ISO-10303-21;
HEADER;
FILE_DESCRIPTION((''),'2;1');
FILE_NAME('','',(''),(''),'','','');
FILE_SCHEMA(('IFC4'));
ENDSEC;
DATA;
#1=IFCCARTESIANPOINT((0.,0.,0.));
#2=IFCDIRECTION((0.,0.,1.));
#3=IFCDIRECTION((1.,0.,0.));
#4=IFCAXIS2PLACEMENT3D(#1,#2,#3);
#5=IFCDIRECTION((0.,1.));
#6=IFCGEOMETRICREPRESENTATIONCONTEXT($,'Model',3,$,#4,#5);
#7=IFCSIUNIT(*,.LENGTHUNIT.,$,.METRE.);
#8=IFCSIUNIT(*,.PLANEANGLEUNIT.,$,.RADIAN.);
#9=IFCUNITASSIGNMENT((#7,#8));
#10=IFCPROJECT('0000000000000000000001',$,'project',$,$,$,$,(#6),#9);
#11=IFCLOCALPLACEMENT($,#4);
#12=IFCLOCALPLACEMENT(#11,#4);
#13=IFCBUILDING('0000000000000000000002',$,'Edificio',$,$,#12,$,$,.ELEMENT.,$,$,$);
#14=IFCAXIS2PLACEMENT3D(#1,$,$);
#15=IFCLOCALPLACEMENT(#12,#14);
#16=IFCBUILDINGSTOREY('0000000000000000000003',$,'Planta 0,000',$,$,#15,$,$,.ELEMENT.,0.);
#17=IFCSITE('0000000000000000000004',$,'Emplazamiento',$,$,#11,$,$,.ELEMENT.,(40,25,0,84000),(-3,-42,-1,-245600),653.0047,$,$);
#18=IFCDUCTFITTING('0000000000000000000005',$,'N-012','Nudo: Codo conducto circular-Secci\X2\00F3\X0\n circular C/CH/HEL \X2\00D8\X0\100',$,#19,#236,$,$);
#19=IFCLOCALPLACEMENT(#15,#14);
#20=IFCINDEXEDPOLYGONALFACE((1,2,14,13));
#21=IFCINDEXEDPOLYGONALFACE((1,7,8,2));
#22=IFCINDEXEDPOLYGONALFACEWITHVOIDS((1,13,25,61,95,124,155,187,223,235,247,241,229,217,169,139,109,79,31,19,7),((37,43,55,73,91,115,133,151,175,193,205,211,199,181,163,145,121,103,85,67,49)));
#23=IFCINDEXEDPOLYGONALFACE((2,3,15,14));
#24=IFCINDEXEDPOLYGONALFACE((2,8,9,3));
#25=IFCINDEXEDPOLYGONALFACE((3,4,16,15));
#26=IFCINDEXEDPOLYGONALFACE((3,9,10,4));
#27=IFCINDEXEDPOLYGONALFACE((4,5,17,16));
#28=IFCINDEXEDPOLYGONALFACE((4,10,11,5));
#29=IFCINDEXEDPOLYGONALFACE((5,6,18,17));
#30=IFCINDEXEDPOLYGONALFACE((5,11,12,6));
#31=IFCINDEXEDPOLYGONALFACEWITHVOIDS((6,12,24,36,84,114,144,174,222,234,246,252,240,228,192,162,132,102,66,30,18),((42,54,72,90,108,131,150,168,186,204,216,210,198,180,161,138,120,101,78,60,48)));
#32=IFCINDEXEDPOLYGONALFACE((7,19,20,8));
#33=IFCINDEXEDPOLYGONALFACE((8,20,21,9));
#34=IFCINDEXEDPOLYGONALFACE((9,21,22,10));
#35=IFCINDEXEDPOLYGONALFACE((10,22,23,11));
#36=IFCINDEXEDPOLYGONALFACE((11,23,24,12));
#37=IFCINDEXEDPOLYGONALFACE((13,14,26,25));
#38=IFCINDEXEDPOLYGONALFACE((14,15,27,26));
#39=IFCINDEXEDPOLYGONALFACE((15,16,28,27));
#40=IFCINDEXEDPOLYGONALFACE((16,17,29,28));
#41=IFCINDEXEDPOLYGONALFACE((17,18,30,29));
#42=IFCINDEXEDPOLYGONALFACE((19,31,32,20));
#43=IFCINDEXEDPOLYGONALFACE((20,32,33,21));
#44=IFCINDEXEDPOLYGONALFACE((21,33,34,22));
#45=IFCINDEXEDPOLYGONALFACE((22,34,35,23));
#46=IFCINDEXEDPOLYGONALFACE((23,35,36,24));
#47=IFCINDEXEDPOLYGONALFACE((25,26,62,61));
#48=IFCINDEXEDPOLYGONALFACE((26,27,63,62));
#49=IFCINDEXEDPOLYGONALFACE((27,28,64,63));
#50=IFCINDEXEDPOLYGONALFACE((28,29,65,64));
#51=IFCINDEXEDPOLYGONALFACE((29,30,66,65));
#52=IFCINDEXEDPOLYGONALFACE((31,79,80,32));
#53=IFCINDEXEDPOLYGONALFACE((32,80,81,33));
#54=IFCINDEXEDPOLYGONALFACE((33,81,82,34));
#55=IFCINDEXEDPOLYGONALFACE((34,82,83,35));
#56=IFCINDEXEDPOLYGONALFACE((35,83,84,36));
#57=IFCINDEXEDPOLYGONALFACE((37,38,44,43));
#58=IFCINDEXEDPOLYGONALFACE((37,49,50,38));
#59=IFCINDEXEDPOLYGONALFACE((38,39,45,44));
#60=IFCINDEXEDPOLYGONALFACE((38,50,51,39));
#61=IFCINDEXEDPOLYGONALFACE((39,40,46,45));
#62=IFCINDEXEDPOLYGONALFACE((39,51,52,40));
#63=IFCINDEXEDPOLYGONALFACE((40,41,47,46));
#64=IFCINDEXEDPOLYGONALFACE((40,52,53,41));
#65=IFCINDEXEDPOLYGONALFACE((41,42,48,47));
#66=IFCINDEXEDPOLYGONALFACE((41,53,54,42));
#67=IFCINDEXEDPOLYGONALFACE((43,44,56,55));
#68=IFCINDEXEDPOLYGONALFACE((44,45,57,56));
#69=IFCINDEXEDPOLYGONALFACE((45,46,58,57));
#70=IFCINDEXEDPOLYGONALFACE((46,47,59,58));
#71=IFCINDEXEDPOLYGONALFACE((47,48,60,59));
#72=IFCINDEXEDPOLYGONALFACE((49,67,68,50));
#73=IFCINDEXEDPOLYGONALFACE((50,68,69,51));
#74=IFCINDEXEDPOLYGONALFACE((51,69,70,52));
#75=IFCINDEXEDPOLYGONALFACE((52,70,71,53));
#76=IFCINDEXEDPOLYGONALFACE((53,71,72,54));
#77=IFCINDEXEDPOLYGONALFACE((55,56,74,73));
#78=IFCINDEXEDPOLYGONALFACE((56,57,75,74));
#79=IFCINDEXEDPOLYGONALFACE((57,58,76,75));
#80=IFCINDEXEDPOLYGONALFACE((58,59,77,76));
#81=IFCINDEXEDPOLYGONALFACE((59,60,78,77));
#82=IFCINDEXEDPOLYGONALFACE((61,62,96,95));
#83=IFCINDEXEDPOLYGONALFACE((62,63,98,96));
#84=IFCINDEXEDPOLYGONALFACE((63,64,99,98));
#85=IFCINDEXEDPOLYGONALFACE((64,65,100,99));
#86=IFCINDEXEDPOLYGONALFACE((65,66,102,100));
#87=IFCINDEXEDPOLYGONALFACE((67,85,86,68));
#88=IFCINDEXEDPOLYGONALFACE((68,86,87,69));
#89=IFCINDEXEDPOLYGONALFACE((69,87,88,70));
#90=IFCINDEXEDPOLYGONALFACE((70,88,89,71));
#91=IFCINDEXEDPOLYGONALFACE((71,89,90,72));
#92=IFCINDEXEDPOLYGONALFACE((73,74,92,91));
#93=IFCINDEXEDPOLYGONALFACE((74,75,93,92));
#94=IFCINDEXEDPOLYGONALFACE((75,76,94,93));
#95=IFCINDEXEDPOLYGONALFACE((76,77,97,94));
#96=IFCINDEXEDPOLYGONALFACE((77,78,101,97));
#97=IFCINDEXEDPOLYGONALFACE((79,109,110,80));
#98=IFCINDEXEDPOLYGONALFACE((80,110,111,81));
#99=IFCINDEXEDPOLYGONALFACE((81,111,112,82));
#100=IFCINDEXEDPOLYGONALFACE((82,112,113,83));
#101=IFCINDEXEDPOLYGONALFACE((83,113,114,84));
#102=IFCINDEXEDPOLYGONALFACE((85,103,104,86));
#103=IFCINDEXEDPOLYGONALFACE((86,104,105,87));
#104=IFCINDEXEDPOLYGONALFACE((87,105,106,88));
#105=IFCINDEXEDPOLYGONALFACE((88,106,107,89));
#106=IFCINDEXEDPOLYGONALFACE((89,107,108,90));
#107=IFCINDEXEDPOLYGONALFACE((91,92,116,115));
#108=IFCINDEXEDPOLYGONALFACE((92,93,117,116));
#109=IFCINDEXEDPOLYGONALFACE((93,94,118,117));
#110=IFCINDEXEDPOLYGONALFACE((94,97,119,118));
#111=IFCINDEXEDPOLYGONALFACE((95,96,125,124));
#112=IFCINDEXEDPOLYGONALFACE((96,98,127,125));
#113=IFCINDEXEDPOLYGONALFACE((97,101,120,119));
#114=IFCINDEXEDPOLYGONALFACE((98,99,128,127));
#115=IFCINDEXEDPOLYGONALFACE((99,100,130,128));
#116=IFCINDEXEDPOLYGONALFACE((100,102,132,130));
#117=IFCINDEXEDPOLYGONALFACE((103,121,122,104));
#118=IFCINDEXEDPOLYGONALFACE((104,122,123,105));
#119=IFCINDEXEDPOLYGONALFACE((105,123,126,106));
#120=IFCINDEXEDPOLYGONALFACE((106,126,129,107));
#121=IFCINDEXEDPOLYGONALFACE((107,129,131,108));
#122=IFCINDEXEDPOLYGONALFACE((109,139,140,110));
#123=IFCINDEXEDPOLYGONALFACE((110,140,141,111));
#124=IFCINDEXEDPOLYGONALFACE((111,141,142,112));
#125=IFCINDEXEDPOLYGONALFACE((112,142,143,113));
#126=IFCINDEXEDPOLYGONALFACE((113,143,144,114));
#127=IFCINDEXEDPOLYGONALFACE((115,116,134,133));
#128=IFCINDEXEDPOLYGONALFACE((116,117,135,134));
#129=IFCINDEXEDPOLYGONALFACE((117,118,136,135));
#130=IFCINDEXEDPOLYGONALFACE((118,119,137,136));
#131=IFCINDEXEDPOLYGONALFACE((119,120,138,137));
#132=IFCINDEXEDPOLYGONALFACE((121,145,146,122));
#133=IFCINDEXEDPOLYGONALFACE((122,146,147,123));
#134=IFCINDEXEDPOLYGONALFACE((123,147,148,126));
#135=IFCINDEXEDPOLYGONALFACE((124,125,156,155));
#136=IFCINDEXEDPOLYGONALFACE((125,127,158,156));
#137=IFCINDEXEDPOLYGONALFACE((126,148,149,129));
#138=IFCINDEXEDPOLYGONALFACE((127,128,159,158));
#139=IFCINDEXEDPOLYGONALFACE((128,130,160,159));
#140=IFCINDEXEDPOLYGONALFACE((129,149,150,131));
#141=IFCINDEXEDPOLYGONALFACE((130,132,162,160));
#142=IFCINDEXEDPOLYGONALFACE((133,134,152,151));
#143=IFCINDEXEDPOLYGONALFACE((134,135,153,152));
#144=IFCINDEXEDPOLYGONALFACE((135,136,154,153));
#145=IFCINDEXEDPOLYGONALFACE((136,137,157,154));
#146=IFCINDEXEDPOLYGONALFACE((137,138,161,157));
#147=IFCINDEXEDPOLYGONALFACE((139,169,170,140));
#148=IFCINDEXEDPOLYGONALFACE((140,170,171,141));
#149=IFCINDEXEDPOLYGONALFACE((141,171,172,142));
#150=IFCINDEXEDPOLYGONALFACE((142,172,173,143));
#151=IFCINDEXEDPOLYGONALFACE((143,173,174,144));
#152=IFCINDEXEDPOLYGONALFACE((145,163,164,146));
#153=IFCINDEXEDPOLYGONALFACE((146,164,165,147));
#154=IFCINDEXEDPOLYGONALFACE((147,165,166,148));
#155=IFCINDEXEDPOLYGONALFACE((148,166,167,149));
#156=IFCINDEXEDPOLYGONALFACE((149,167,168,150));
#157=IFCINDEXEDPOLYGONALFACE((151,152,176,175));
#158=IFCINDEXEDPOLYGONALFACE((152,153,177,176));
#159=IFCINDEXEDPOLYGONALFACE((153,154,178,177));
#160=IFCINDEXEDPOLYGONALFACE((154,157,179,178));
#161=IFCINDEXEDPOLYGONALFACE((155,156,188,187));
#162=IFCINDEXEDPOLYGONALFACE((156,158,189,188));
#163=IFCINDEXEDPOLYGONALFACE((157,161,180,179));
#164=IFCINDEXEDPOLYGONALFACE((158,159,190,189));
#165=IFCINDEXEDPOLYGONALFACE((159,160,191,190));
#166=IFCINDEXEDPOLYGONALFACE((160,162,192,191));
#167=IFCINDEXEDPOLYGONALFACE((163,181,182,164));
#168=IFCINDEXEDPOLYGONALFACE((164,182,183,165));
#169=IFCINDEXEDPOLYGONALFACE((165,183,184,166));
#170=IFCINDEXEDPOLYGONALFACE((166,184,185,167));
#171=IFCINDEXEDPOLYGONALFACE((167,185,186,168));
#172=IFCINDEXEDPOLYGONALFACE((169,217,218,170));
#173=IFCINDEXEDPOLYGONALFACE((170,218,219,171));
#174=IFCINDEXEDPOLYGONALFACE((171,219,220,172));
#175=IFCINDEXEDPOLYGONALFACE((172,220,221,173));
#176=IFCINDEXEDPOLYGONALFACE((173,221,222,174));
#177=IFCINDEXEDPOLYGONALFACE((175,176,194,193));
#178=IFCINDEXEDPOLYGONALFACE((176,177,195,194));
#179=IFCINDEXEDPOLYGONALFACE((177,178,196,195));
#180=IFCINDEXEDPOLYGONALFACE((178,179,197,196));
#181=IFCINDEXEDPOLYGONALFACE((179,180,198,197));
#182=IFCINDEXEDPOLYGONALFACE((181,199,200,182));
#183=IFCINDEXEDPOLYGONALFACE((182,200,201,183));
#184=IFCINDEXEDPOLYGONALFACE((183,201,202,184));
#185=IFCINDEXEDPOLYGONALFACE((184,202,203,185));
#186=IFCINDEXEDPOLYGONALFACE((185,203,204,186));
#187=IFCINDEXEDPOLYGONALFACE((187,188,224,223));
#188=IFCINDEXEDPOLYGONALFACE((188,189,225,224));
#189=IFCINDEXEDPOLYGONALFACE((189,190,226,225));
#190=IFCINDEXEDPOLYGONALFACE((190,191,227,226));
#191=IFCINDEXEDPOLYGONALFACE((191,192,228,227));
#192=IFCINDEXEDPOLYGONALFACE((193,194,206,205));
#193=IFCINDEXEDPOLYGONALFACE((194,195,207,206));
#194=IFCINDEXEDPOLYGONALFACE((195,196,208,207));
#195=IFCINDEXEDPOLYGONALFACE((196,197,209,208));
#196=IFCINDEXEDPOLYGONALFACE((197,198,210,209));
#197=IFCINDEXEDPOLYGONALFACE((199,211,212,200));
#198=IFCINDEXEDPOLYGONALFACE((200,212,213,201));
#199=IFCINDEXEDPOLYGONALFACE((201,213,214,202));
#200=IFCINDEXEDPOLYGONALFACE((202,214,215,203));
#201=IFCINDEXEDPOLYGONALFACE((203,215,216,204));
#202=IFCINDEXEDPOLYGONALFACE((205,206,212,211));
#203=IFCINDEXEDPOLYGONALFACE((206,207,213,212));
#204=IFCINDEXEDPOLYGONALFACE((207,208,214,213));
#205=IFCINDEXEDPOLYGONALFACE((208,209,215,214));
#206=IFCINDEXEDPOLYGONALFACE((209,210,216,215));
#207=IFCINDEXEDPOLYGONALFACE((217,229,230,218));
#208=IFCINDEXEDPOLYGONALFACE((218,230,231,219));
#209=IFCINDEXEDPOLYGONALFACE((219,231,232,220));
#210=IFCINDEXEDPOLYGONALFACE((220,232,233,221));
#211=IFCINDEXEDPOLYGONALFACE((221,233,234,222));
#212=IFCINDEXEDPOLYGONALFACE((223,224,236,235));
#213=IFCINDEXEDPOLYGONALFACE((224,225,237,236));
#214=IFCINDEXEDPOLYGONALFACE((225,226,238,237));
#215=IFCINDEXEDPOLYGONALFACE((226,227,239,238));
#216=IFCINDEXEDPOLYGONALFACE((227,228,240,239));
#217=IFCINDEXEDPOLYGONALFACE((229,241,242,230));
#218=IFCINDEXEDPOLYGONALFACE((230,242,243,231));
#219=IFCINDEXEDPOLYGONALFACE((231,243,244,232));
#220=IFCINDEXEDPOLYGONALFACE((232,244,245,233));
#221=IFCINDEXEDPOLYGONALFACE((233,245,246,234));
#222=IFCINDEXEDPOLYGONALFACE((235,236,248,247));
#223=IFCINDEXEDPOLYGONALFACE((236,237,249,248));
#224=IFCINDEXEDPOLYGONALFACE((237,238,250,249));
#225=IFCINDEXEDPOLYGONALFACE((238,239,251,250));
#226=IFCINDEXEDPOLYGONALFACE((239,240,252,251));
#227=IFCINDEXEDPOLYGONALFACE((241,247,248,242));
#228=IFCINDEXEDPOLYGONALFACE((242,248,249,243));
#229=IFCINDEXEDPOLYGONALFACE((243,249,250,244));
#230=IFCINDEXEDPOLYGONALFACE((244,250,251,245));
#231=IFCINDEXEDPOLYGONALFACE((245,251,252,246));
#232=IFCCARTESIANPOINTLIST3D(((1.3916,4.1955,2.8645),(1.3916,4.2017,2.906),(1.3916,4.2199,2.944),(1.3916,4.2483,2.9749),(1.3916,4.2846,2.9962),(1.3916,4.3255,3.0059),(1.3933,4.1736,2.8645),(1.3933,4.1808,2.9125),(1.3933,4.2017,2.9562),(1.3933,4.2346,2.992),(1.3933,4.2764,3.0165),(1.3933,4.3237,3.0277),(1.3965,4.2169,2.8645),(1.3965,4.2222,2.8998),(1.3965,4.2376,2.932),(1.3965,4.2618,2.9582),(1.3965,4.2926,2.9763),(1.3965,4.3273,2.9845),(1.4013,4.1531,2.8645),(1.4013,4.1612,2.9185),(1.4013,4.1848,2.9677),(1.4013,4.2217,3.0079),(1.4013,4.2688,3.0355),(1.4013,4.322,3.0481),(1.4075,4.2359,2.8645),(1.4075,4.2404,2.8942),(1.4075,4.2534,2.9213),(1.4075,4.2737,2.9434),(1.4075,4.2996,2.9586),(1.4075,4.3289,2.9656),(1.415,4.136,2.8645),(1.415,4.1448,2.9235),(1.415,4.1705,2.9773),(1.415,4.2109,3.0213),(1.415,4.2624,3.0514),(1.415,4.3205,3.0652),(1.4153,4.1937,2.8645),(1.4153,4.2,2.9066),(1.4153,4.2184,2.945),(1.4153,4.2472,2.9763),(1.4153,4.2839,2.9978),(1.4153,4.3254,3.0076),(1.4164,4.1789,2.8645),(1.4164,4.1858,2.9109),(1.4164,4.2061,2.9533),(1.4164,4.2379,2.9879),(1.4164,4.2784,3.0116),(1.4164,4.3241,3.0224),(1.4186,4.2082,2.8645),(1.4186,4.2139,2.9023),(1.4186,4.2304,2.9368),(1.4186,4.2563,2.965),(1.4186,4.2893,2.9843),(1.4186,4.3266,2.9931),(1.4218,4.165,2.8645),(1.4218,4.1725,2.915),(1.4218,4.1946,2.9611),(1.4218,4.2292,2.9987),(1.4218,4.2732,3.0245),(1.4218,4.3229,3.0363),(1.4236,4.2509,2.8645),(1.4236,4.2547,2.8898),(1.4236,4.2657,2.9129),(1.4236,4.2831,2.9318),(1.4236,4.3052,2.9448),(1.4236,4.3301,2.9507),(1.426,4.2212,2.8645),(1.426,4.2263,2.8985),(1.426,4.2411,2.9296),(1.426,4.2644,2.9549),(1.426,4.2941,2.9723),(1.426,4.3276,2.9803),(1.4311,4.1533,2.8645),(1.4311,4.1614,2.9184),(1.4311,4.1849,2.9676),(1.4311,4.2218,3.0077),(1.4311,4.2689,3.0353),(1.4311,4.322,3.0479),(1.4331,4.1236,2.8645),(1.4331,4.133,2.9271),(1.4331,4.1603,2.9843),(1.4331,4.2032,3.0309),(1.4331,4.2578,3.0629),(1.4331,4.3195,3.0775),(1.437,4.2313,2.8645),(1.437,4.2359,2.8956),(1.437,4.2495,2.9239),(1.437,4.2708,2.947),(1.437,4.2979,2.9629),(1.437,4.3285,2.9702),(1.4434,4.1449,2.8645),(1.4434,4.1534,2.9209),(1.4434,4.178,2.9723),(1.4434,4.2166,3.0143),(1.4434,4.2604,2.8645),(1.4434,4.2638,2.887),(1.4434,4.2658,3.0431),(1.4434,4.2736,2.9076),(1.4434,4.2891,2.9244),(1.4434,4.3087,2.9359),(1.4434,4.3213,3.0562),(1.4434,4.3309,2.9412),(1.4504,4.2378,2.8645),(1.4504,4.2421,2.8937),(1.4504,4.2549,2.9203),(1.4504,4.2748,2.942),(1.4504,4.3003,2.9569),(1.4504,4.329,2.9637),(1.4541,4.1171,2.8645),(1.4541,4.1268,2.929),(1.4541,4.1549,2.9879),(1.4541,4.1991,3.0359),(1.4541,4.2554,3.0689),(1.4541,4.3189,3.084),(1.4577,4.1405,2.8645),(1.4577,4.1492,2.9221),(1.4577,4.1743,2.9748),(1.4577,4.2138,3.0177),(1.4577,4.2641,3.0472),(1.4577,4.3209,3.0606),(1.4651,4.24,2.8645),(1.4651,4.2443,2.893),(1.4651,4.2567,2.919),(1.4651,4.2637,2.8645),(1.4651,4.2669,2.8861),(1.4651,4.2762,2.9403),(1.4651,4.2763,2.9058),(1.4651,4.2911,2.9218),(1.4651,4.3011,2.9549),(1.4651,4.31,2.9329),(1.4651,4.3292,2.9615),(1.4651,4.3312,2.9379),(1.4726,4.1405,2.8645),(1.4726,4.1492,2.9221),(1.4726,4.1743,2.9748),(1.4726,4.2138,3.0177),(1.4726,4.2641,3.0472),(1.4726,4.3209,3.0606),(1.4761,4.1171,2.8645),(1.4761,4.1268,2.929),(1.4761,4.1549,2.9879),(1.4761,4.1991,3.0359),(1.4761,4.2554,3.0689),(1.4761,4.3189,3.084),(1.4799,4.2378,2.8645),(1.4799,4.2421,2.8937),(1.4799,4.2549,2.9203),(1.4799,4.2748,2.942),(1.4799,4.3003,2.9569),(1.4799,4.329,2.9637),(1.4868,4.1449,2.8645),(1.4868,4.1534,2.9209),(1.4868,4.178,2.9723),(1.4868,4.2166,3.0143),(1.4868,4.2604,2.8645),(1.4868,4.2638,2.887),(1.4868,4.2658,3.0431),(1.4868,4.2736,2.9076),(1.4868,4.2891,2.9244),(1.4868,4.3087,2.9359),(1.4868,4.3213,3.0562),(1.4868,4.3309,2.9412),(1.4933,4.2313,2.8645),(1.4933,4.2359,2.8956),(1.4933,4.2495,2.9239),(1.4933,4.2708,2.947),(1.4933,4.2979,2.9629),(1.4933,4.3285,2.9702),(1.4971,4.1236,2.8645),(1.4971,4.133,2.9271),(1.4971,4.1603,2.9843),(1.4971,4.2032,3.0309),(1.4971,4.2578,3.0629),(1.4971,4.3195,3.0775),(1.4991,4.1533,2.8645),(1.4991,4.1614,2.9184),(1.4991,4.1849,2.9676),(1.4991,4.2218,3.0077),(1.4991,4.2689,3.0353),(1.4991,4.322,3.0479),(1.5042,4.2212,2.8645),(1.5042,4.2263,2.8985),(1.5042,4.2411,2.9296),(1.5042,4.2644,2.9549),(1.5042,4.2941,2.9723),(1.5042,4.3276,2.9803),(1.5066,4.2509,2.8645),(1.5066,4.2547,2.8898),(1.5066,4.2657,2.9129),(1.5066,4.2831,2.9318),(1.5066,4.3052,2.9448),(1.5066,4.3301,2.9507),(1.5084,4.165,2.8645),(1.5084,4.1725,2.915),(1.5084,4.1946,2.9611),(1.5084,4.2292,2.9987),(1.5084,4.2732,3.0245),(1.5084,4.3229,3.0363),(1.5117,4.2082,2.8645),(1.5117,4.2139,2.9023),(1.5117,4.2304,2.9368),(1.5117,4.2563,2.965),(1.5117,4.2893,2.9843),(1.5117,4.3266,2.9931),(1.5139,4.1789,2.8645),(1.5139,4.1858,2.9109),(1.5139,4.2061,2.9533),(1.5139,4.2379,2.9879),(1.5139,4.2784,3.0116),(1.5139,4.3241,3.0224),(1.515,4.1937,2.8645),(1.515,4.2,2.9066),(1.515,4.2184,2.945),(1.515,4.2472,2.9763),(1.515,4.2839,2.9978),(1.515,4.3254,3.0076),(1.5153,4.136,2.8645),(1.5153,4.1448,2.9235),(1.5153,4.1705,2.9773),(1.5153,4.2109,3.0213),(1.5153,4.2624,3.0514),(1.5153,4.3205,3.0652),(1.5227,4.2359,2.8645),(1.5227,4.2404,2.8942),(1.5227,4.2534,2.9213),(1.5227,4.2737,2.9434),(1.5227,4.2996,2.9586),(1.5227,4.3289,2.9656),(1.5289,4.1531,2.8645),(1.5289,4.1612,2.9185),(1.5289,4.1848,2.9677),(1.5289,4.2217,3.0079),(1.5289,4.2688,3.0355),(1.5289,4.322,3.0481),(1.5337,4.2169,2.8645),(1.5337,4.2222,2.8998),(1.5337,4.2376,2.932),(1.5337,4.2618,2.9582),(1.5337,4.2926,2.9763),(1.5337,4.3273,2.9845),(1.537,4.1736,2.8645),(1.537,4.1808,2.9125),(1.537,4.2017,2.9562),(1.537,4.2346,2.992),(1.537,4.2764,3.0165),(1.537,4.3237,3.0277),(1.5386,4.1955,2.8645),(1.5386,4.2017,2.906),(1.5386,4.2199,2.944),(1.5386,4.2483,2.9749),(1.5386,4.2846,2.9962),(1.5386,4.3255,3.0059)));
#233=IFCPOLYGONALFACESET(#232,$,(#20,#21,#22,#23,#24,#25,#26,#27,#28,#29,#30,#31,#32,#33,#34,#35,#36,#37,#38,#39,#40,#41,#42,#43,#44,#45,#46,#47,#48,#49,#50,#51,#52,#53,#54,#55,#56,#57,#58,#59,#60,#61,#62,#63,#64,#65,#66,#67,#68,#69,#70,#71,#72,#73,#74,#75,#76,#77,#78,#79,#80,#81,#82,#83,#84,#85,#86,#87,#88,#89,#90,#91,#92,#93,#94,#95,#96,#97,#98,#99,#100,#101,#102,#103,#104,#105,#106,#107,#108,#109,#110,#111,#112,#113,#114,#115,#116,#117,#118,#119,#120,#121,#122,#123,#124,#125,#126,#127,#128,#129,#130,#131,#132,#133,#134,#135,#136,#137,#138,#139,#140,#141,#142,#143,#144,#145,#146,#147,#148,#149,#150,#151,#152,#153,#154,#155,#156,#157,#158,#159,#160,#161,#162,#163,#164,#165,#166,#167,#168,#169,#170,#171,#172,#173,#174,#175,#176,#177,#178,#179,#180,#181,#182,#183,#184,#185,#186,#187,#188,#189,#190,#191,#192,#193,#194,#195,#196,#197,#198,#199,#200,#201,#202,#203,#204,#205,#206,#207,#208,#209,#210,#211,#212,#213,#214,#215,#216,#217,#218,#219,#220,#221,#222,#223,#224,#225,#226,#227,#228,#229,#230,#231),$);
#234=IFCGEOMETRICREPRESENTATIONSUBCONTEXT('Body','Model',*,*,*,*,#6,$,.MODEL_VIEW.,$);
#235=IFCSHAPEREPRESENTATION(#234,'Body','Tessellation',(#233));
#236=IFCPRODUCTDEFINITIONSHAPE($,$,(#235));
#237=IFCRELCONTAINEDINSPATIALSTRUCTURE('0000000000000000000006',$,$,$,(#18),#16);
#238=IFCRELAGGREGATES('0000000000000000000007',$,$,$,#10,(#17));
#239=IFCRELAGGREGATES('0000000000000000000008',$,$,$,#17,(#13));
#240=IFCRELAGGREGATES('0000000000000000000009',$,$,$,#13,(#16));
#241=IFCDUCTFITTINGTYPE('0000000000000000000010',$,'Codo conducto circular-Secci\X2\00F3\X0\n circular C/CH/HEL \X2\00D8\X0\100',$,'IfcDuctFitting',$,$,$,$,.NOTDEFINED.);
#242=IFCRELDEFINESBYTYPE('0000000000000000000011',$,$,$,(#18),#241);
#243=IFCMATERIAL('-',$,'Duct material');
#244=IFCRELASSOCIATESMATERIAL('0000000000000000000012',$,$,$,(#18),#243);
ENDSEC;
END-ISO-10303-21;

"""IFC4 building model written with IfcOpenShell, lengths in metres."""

from ifc_helpers import new_model, entity, si_unit, direction, origin, origin_with_axes, place, context, subcontext, project, spatial, source, transform, mapped, material, type_object, element, save


model = new_model("IFC4")

# Units and contexts
model_context = context("Model", 3, world=origin_with_axes(), true_north=direction((0.0, 1.0)))
body_context = subcontext(model_context, "Body", "Model", "MODEL_VIEW")
ifc_project = project(units=[si_unit("LENGTHUNIT", "METRE"), si_unit("PLANEANGLEUNIT", "RADIAN")], contexts=[model_context])

# Site, building, storey
site_placement = place(None, origin_with_axes())
site = spatial("IfcSite", under=ifc_project, at=site_placement, Name="Emplazamiento", CompositionType="ELEMENT", RefLatitude=(40, 25, 0, 84000), RefLongitude=(-3, -42, -1, -245600), RefElevation=653.0047)
building_placement = place(site_placement, origin_with_axes())
building = spatial("IfcBuilding", under=site, at=building_placement, Name="Edificio", CompositionType="ELEMENT")
storey_placement = place(building_placement, origin())
storey = spatial("IfcBuildingStorey", under=building, at=storey_placement, Name="Planta 0,000", CompositionType="ELEMENT", Elevation=0.0)

# Duct fitting
ifc_material_1 = material(Name="-", Category="Duct material")
duct_fitting_type_1 = type_object("IfcDuctFittingType", Name="Codo conducto circular-Sección circular C/CH/HEL Ø100", ApplicableOccurrence="IfcDuctFitting", PredefinedType="NOTDEFINED")
shared_shape_1 = source(origin_with_axes(), body_context, "Body", "SweptSolid", [
    entity("IfcRevolvedAreaSolid", entity("IfcCircleHollowProfileDef", "AREA", None, entity("IfcAxis2Placement2D", entity("IfcCartesianPoint", [0.0, 0.0]), entity("IfcDirection", [1.0, 0.0])), 0.0737, 0.0237), entity("IfcAxis2Placement3D", entity("IfcCartesianPoint", [0.1351, 0.0113, 0.0]), entity("IfcDirection", [-0.99649, -0.083712, 0.0]), entity("IfcDirection", [0.083712, -0.99649, 0.0])), entity("IfcAxis1Placement", entity("IfcCartesianPoint", [0.1474, 0.0, 0.0]), entity("IfcDirection", [0.0, 1.0, 0.0])), 1.486986),
])
duct_fitting_1_placement = place(storey_placement, origin_with_axes())
element("IfcDuctFitting", 1, at=duct_fitting_1_placement, inside=storey, type_object=duct_fitting_type_1, material=ifc_material_1, Name="N-012", Description="Nudo: Codo conducto circular-Sección circular C/CH/HEL Ø100", context=body_context, shape_type="MappedRepresentation", body=[
    mapped(shared_shape_1, transform((1.4651, 4.19, 3.0), x_axis=(0.0, 0.083712, -0.99649), y_axis=(0.0, -0.99649, -0.083712), z_axis=(-1.0, 0.0, 0.0), scale=1.0)),
])

save(model, "model.ifc")
